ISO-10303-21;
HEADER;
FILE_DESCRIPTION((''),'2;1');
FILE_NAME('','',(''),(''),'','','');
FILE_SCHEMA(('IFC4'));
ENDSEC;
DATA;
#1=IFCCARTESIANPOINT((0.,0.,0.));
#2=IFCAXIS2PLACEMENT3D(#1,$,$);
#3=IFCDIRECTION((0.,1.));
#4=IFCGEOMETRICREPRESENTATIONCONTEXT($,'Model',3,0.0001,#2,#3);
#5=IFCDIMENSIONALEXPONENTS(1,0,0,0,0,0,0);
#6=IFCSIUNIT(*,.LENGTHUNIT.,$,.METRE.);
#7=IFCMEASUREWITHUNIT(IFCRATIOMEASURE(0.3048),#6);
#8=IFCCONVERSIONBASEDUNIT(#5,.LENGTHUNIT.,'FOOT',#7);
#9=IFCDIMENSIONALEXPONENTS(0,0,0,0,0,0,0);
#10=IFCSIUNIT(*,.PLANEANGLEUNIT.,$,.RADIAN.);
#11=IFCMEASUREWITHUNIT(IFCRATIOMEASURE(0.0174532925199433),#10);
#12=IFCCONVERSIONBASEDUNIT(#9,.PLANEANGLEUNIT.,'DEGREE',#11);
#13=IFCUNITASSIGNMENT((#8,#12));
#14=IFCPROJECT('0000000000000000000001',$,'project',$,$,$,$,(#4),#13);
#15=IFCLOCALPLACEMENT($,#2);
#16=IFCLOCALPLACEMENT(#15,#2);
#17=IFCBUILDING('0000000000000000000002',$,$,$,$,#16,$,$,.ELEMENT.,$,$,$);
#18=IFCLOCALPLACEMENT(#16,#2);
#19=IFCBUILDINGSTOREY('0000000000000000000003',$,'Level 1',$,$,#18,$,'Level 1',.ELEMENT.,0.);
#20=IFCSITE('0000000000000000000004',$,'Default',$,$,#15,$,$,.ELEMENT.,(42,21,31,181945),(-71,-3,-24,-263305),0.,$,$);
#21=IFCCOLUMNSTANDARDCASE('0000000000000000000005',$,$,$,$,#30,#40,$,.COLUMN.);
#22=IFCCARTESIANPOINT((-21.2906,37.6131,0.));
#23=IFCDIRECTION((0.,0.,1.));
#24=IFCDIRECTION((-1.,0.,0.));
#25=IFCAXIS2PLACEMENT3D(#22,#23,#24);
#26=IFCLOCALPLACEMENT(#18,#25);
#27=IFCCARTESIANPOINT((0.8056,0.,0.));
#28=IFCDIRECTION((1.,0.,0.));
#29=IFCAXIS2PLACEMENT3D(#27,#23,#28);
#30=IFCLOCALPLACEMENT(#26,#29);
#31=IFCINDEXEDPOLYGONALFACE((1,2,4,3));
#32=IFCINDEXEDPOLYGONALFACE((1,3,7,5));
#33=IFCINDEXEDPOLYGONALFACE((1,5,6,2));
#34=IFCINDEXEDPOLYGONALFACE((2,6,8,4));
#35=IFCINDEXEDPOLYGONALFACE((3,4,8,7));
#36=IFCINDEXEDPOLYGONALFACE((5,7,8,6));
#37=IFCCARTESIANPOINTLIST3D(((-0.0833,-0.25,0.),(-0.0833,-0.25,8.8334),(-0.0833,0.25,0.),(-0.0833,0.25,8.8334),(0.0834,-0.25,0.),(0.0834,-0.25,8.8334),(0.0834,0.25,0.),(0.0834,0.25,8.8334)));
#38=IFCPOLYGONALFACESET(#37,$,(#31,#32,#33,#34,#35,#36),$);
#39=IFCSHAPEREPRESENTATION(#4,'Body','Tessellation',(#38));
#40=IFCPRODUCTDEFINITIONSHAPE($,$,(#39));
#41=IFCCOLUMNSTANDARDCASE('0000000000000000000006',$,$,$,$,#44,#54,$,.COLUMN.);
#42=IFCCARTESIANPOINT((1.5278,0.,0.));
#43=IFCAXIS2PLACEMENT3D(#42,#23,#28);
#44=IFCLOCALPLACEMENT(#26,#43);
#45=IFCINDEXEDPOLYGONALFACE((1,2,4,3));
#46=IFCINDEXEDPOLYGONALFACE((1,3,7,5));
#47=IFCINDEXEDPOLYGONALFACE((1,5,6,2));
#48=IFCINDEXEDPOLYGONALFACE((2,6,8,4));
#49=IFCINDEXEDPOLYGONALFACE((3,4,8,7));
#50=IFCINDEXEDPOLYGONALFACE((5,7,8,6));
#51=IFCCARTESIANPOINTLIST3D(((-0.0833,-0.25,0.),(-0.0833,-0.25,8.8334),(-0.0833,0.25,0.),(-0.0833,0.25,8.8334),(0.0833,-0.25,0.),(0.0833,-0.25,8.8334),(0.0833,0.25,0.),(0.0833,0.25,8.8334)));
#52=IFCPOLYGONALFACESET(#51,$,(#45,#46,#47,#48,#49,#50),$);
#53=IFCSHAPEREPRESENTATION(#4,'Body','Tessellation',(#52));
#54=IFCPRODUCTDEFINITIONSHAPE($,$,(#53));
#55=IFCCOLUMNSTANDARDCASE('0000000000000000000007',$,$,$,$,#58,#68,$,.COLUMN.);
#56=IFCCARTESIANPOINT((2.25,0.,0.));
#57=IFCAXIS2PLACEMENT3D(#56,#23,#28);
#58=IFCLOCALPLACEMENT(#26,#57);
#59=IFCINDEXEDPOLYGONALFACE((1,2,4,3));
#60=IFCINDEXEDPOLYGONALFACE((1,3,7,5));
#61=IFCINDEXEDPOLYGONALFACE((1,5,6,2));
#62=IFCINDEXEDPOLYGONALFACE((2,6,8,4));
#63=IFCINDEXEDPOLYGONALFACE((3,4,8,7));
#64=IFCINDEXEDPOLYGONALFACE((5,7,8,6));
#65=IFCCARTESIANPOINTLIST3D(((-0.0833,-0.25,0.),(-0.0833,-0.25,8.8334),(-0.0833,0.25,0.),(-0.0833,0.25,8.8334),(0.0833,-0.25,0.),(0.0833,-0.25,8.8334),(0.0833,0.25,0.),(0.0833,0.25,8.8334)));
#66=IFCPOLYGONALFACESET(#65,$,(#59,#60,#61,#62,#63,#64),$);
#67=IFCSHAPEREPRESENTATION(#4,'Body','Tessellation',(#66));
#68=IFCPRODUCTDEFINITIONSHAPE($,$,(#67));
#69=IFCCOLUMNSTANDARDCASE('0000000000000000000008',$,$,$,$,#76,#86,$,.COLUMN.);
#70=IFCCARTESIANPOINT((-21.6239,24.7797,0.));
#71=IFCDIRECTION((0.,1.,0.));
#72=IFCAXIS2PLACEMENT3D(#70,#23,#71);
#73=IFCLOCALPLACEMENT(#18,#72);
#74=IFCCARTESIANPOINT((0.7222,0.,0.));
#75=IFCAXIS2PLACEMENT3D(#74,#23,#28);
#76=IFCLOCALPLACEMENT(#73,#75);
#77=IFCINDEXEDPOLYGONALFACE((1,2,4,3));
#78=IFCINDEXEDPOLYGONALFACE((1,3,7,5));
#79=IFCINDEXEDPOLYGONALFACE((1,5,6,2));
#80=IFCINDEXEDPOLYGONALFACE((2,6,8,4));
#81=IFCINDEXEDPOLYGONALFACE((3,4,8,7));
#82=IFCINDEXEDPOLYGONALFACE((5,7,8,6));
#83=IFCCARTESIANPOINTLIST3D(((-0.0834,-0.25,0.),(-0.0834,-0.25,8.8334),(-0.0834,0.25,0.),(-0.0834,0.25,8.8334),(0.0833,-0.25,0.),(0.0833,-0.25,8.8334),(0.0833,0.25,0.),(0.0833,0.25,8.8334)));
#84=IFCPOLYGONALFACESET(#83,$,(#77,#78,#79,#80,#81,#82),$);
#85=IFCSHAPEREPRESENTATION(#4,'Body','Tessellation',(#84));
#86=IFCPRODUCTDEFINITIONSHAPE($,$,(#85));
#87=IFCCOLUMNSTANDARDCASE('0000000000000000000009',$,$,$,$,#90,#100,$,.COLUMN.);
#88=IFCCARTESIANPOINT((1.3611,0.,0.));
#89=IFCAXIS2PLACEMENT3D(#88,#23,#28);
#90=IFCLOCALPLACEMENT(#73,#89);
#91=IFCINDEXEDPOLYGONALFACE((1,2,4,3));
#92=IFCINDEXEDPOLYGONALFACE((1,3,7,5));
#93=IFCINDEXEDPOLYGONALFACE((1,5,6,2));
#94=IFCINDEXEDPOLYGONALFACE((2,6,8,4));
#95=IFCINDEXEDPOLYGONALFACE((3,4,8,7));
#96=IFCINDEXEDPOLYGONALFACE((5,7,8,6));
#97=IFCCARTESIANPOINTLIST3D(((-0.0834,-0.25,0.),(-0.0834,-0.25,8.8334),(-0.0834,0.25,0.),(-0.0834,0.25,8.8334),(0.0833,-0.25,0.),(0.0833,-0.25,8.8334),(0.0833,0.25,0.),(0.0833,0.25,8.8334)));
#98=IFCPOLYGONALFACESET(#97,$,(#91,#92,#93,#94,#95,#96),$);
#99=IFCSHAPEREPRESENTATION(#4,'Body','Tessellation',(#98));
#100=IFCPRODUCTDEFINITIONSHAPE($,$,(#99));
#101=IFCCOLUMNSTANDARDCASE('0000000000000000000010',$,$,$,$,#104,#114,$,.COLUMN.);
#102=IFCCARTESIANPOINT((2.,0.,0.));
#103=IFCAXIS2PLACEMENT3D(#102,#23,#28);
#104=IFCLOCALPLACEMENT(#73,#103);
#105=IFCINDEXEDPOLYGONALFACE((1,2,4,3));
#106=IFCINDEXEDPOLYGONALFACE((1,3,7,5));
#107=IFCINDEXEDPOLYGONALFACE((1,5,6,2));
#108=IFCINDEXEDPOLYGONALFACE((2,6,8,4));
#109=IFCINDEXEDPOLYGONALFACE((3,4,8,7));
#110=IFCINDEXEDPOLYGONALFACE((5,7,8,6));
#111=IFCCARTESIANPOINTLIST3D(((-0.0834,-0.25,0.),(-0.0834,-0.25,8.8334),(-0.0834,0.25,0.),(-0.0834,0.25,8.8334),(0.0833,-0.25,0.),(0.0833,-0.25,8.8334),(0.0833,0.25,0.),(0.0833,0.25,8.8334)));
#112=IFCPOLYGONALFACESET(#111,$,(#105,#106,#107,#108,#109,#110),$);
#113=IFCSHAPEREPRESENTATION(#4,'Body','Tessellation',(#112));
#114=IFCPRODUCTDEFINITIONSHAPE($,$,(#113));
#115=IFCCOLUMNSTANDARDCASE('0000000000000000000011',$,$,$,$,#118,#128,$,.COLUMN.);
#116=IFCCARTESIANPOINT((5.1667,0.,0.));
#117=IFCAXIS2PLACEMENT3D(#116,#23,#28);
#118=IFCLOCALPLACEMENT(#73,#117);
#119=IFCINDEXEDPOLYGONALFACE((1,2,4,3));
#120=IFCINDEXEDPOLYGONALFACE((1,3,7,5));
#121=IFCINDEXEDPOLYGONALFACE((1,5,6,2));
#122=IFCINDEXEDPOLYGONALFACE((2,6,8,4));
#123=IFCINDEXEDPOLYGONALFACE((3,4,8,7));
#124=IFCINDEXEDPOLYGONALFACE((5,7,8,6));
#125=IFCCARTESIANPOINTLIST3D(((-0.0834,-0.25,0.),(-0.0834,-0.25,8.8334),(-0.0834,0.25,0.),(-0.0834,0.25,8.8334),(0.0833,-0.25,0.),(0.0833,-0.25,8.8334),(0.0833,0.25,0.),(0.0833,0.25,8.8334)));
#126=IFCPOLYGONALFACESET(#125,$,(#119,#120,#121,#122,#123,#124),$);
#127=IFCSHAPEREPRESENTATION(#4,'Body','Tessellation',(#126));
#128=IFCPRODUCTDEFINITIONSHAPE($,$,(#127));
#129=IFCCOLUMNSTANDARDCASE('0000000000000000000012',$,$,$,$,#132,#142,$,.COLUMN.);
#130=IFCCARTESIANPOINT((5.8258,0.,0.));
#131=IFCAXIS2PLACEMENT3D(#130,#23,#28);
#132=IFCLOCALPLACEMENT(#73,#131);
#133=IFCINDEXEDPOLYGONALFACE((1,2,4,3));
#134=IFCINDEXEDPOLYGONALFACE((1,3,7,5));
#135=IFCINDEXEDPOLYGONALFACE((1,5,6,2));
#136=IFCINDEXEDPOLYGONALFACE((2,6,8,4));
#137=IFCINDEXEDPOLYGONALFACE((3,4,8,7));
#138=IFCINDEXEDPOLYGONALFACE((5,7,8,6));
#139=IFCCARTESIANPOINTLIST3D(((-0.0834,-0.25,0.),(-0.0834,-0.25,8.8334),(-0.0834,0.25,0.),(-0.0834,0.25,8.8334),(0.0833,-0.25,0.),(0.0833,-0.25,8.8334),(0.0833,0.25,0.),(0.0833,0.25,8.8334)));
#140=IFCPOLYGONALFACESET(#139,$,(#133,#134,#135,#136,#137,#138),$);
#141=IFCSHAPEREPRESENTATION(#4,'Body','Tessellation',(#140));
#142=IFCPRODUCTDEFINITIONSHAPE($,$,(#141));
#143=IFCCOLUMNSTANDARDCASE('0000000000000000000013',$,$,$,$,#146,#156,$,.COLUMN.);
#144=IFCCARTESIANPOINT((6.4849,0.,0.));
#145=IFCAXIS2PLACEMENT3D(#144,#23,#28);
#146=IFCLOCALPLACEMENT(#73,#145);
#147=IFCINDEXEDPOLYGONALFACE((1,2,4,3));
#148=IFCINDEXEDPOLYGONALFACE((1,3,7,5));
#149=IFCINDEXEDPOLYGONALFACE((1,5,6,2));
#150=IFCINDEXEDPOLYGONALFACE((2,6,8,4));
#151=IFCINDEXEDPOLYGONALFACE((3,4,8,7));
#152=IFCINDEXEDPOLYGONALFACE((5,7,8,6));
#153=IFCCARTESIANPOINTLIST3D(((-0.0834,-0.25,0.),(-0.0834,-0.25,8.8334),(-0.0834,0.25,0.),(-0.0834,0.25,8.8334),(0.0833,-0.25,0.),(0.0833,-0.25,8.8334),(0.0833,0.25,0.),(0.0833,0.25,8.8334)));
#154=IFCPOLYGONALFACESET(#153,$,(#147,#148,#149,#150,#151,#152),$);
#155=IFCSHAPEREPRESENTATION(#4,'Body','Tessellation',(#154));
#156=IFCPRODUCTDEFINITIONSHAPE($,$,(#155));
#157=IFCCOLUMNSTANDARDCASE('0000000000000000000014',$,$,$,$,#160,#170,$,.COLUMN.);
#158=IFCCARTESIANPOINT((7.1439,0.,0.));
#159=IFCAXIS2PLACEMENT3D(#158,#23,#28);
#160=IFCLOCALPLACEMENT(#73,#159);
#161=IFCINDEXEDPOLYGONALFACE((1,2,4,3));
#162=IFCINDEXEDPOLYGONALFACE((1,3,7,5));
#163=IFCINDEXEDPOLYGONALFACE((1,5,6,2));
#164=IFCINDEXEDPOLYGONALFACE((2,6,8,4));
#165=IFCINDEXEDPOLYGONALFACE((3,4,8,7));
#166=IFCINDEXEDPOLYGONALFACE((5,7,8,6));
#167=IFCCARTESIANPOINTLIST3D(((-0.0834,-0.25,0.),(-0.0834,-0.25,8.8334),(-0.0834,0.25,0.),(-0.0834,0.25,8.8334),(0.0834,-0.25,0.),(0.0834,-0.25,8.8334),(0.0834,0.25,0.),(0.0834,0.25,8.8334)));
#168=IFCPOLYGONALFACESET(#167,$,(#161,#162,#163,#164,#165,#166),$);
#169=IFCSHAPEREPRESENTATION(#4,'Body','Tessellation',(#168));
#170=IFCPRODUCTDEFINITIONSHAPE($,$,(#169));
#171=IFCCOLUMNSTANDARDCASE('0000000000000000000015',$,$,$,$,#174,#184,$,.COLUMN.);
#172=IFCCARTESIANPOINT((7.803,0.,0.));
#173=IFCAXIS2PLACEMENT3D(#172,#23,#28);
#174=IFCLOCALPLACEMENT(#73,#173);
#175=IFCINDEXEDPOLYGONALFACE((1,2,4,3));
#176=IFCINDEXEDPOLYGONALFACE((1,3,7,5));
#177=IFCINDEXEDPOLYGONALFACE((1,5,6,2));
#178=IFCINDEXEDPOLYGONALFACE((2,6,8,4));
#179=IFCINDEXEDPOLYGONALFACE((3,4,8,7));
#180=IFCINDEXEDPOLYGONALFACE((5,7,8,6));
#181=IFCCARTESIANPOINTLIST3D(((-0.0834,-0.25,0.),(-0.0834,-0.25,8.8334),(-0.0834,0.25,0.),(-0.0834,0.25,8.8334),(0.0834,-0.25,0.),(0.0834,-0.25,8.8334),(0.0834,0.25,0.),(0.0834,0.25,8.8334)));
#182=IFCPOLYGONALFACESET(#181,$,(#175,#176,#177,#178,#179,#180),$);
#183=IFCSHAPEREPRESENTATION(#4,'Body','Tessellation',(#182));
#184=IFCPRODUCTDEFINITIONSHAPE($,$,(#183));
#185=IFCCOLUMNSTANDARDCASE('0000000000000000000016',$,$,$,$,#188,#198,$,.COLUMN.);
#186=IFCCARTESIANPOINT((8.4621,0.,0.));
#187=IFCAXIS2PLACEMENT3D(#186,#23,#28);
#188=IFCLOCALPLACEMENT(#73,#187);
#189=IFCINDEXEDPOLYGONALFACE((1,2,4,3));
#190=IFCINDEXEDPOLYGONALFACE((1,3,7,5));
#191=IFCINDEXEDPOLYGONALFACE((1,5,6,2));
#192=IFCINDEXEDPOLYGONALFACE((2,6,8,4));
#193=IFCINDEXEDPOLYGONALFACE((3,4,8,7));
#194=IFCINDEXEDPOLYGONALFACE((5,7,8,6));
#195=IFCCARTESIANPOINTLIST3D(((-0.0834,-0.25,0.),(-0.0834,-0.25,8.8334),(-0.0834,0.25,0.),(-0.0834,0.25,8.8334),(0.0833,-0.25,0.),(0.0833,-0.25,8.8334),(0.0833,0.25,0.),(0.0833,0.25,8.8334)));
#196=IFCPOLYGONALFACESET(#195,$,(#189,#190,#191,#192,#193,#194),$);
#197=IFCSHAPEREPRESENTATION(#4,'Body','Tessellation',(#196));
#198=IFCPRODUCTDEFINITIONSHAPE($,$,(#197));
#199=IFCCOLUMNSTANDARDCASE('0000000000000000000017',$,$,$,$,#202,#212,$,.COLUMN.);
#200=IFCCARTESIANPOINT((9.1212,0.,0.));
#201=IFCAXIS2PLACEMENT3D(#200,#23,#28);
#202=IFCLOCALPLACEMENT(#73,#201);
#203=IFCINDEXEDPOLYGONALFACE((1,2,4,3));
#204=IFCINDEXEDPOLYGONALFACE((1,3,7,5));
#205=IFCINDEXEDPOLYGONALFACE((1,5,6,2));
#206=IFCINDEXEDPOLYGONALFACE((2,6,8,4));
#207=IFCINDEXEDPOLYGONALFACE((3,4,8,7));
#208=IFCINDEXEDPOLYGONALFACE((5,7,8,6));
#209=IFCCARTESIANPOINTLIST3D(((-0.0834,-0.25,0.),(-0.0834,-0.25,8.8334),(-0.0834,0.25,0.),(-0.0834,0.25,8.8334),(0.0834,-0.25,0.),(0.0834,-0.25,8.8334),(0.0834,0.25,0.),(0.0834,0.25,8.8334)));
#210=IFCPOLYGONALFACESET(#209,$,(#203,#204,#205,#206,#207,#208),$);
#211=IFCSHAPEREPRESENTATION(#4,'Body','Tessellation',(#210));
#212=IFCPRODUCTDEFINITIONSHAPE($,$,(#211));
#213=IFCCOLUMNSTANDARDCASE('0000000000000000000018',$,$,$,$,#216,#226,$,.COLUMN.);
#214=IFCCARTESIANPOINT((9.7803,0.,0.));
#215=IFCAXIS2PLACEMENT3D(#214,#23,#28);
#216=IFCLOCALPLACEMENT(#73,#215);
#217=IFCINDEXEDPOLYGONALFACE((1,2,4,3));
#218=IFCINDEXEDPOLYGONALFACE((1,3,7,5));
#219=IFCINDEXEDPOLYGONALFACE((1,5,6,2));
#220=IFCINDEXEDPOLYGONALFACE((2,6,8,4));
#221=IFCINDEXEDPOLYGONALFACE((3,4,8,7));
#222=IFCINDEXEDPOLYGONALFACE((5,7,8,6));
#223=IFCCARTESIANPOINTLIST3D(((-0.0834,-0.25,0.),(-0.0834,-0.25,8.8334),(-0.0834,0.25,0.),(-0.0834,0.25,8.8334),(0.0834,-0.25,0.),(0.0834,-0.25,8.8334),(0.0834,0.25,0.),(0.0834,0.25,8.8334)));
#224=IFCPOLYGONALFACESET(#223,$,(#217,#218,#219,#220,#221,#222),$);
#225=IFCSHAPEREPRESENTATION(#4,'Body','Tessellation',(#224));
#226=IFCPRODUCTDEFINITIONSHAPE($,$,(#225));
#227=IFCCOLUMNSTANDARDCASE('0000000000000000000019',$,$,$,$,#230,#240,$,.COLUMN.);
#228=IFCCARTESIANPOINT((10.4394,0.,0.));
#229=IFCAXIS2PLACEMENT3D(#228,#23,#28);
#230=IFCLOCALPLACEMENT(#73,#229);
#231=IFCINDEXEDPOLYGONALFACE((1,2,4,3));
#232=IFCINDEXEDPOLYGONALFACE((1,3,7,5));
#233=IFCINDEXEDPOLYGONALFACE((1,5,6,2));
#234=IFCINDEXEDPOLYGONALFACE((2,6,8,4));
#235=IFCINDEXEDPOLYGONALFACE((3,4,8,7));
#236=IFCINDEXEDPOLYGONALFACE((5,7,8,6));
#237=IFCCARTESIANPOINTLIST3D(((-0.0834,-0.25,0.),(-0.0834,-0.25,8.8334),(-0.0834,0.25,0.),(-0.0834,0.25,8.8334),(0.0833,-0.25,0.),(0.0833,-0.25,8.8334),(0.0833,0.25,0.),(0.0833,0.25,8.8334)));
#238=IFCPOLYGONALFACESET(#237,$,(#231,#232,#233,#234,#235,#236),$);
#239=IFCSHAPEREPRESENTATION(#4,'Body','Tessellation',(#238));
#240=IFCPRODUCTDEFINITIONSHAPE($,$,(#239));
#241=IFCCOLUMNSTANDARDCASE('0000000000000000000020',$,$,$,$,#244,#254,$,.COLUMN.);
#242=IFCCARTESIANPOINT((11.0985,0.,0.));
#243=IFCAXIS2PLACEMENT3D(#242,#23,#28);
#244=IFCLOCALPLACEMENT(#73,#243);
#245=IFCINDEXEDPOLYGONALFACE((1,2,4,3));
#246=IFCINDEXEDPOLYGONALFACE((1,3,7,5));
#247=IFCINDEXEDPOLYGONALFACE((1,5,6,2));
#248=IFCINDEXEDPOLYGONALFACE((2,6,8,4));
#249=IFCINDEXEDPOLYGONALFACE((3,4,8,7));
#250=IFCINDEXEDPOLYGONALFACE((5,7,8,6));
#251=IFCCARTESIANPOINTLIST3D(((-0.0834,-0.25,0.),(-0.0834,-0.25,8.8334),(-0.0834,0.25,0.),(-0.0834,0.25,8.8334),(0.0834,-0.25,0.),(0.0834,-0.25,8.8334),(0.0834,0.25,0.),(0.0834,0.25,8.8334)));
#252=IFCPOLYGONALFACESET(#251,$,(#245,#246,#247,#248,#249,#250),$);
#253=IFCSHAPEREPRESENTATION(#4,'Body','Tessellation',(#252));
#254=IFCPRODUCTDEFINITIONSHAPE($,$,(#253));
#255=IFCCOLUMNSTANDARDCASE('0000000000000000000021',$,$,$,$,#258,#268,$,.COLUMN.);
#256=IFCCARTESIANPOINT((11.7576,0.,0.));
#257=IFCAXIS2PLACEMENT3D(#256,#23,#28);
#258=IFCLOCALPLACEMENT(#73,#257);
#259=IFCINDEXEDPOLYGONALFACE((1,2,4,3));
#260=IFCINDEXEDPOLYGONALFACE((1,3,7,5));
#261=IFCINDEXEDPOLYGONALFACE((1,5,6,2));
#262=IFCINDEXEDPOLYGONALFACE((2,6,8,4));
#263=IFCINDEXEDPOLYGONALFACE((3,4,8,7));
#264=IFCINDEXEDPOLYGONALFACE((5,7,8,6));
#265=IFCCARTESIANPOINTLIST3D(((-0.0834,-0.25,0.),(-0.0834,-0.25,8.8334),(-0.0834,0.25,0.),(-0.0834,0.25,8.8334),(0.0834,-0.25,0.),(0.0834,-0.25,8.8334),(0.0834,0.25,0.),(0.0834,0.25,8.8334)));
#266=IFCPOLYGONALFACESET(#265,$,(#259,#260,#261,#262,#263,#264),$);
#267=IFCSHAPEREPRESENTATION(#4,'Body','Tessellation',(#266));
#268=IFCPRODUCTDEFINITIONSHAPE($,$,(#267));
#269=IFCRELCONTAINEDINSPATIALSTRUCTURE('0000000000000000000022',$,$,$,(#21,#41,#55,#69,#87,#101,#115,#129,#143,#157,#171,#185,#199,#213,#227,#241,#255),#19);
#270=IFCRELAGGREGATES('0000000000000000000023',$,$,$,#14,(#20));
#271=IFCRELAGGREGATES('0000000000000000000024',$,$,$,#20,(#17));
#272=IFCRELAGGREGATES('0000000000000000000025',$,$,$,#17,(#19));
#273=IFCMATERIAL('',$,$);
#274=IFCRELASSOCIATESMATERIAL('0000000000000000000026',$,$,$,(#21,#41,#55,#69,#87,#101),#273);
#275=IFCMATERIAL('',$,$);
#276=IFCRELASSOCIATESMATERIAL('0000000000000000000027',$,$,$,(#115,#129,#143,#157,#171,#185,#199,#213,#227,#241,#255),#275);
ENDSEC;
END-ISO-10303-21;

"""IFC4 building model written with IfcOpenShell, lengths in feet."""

from ifc_helpers import new_model, entity, si_unit, converted_unit, direction, frame, origin, place, context, project, spatial, rectangle, extrude, material, element, save


model = new_model("IFC4")

# Units and contexts
model_context = context("Model", 3, precision=0.0001, world=origin(), true_north=direction((0.0, 1.0)))
ifc_project = project(units=[converted_unit("LENGTHUNIT", "FOOT", entity("IfcRatioMeasure", 0.3048), si_unit("LENGTHUNIT", "METRE"), dimensions=[1, 0, 0, 0, 0, 0, 0]), converted_unit("PLANEANGLEUNIT", "DEGREE", entity("IfcRatioMeasure", 0.0174532925199433), si_unit("PLANEANGLEUNIT", "RADIAN"), dimensions=[0, 0, 0, 0, 0, 0, 0])], contexts=[model_context])

# Site, building, storey
site_placement = place(None, origin())
site = spatial("IfcSite", under=ifc_project, at=site_placement, Name="Default", CompositionType="ELEMENT", RefLatitude=(42, 21, 31, 181945), RefLongitude=(-71, -3, -24, -263305), RefElevation=0.0)
building_placement = place(site_placement, origin())
building = spatial("IfcBuilding", under=site, at=building_placement, CompositionType="ELEMENT")
storey_placement = place(building_placement, origin())
storey = spatial("IfcBuildingStorey", under=building, at=storey_placement, Name="Level 1", LongName="Level 1", CompositionType="ELEMENT", Elevation=0.0)

# Columns
ifc_material_1 = material(Name="")
placement_1 = place(storey_placement, frame((-21.2906, 37.6131, 0.0), z_axis=(0.0, 0.0, 1.0), x_axis=(-1.0, 0.0, 0.0)))
for number, where, z_axis, x_axis in (
    (1, (0.8056, 0.0, 0.0), (0.0, 0.0, 1.0), (1.0, 0.0, 0.0)),
    (2, (1.5278, 0.0, 0.0), (0.0, 0.0, 1.0), (1.0, 0.0, 0.0)),
    (3, (2.25, 0.0, 0.0), (0.0, 0.0, 1.0), (1.0, 0.0, 0.0)),
):
    element("IfcColumnStandardCase", number, at=place(placement_1, frame(where, z_axis=z_axis, x_axis=x_axis)), inside=storey, material=ifc_material_1, PredefinedType="COLUMN", context=model_context, shape_type="SweptSolid", body=[
        extrude(rectangle(XDim=0.1667, YDim=0.5), origin(), (0.0, 0.0, 1.0), 8.8334),
    ])
placement_2 = place(storey_placement, frame((-21.6239, 24.7797, 0.0), z_axis=(0.0, 0.0, 1.0), x_axis=(0.0, 1.0, 0.0)))
for number, where, z_axis, x_axis in (
    (4, (0.7222, 0.0, 0.0), (0.0, 0.0, 1.0), (1.0, 0.0, 0.0)),
    (5, (1.3611, 0.0, 0.0), (0.0, 0.0, 1.0), (1.0, 0.0, 0.0)),
    (6, (2.0, 0.0, 0.0), (0.0, 0.0, 1.0), (1.0, 0.0, 0.0)),
):
    element("IfcColumnStandardCase", number, at=place(placement_2, frame(where, z_axis=z_axis, x_axis=x_axis)), inside=storey, material=ifc_material_1, PredefinedType="COLUMN", context=model_context, shape_type="SweptSolid", body=[
        extrude(rectangle(XDim=0.1667, YDim=0.5), origin(), (0.0, 0.0, 1.0), 8.8334),
    ])
ifc_material_2 = material(Name="")
for number, where, z_axis, x_axis in (
    (7, (5.1667, 0.0, 0.0), (0.0, 0.0, 1.0), (1.0, 0.0, 0.0)),
    (8, (5.8258, 0.0, 0.0), (0.0, 0.0, 1.0), (1.0, 0.0, 0.0)),
    (9, (6.4849, 0.0, 0.0), (0.0, 0.0, 1.0), (1.0, 0.0, 0.0)),
    (10, (7.1439, 0.0, 0.0), (0.0, 0.0, 1.0), (1.0, 0.0, 0.0)),
    (11, (7.803, 0.0, 0.0), (0.0, 0.0, 1.0), (1.0, 0.0, 0.0)),
    (12, (8.4621, 0.0, 0.0), (0.0, 0.0, 1.0), (1.0, 0.0, 0.0)),
    (13, (9.1212, 0.0, 0.0), (0.0, 0.0, 1.0), (1.0, 0.0, 0.0)),
    (14, (9.7803, 0.0, 0.0), (0.0, 0.0, 1.0), (1.0, 0.0, 0.0)),
    (15, (10.4394, 0.0, 0.0), (0.0, 0.0, 1.0), (1.0, 0.0, 0.0)),
    (16, (11.0985, 0.0, 0.0), (0.0, 0.0, 1.0), (1.0, 0.0, 0.0)),
    (17, (11.7576, 0.0, 0.0), (0.0, 0.0, 1.0), (1.0, 0.0, 0.0)),
):
    element("IfcColumnStandardCase", number, at=place(placement_2, frame(where, z_axis=z_axis, x_axis=x_axis)), inside=storey, material=ifc_material_2, PredefinedType="COLUMN", context=model_context, shape_type="SweptSolid", body=[
        extrude(rectangle(XDim=0.1667, YDim=0.5), origin(), (0.0, 0.0, 1.0), 8.8334),
    ])

save(model, "model.ifc")
